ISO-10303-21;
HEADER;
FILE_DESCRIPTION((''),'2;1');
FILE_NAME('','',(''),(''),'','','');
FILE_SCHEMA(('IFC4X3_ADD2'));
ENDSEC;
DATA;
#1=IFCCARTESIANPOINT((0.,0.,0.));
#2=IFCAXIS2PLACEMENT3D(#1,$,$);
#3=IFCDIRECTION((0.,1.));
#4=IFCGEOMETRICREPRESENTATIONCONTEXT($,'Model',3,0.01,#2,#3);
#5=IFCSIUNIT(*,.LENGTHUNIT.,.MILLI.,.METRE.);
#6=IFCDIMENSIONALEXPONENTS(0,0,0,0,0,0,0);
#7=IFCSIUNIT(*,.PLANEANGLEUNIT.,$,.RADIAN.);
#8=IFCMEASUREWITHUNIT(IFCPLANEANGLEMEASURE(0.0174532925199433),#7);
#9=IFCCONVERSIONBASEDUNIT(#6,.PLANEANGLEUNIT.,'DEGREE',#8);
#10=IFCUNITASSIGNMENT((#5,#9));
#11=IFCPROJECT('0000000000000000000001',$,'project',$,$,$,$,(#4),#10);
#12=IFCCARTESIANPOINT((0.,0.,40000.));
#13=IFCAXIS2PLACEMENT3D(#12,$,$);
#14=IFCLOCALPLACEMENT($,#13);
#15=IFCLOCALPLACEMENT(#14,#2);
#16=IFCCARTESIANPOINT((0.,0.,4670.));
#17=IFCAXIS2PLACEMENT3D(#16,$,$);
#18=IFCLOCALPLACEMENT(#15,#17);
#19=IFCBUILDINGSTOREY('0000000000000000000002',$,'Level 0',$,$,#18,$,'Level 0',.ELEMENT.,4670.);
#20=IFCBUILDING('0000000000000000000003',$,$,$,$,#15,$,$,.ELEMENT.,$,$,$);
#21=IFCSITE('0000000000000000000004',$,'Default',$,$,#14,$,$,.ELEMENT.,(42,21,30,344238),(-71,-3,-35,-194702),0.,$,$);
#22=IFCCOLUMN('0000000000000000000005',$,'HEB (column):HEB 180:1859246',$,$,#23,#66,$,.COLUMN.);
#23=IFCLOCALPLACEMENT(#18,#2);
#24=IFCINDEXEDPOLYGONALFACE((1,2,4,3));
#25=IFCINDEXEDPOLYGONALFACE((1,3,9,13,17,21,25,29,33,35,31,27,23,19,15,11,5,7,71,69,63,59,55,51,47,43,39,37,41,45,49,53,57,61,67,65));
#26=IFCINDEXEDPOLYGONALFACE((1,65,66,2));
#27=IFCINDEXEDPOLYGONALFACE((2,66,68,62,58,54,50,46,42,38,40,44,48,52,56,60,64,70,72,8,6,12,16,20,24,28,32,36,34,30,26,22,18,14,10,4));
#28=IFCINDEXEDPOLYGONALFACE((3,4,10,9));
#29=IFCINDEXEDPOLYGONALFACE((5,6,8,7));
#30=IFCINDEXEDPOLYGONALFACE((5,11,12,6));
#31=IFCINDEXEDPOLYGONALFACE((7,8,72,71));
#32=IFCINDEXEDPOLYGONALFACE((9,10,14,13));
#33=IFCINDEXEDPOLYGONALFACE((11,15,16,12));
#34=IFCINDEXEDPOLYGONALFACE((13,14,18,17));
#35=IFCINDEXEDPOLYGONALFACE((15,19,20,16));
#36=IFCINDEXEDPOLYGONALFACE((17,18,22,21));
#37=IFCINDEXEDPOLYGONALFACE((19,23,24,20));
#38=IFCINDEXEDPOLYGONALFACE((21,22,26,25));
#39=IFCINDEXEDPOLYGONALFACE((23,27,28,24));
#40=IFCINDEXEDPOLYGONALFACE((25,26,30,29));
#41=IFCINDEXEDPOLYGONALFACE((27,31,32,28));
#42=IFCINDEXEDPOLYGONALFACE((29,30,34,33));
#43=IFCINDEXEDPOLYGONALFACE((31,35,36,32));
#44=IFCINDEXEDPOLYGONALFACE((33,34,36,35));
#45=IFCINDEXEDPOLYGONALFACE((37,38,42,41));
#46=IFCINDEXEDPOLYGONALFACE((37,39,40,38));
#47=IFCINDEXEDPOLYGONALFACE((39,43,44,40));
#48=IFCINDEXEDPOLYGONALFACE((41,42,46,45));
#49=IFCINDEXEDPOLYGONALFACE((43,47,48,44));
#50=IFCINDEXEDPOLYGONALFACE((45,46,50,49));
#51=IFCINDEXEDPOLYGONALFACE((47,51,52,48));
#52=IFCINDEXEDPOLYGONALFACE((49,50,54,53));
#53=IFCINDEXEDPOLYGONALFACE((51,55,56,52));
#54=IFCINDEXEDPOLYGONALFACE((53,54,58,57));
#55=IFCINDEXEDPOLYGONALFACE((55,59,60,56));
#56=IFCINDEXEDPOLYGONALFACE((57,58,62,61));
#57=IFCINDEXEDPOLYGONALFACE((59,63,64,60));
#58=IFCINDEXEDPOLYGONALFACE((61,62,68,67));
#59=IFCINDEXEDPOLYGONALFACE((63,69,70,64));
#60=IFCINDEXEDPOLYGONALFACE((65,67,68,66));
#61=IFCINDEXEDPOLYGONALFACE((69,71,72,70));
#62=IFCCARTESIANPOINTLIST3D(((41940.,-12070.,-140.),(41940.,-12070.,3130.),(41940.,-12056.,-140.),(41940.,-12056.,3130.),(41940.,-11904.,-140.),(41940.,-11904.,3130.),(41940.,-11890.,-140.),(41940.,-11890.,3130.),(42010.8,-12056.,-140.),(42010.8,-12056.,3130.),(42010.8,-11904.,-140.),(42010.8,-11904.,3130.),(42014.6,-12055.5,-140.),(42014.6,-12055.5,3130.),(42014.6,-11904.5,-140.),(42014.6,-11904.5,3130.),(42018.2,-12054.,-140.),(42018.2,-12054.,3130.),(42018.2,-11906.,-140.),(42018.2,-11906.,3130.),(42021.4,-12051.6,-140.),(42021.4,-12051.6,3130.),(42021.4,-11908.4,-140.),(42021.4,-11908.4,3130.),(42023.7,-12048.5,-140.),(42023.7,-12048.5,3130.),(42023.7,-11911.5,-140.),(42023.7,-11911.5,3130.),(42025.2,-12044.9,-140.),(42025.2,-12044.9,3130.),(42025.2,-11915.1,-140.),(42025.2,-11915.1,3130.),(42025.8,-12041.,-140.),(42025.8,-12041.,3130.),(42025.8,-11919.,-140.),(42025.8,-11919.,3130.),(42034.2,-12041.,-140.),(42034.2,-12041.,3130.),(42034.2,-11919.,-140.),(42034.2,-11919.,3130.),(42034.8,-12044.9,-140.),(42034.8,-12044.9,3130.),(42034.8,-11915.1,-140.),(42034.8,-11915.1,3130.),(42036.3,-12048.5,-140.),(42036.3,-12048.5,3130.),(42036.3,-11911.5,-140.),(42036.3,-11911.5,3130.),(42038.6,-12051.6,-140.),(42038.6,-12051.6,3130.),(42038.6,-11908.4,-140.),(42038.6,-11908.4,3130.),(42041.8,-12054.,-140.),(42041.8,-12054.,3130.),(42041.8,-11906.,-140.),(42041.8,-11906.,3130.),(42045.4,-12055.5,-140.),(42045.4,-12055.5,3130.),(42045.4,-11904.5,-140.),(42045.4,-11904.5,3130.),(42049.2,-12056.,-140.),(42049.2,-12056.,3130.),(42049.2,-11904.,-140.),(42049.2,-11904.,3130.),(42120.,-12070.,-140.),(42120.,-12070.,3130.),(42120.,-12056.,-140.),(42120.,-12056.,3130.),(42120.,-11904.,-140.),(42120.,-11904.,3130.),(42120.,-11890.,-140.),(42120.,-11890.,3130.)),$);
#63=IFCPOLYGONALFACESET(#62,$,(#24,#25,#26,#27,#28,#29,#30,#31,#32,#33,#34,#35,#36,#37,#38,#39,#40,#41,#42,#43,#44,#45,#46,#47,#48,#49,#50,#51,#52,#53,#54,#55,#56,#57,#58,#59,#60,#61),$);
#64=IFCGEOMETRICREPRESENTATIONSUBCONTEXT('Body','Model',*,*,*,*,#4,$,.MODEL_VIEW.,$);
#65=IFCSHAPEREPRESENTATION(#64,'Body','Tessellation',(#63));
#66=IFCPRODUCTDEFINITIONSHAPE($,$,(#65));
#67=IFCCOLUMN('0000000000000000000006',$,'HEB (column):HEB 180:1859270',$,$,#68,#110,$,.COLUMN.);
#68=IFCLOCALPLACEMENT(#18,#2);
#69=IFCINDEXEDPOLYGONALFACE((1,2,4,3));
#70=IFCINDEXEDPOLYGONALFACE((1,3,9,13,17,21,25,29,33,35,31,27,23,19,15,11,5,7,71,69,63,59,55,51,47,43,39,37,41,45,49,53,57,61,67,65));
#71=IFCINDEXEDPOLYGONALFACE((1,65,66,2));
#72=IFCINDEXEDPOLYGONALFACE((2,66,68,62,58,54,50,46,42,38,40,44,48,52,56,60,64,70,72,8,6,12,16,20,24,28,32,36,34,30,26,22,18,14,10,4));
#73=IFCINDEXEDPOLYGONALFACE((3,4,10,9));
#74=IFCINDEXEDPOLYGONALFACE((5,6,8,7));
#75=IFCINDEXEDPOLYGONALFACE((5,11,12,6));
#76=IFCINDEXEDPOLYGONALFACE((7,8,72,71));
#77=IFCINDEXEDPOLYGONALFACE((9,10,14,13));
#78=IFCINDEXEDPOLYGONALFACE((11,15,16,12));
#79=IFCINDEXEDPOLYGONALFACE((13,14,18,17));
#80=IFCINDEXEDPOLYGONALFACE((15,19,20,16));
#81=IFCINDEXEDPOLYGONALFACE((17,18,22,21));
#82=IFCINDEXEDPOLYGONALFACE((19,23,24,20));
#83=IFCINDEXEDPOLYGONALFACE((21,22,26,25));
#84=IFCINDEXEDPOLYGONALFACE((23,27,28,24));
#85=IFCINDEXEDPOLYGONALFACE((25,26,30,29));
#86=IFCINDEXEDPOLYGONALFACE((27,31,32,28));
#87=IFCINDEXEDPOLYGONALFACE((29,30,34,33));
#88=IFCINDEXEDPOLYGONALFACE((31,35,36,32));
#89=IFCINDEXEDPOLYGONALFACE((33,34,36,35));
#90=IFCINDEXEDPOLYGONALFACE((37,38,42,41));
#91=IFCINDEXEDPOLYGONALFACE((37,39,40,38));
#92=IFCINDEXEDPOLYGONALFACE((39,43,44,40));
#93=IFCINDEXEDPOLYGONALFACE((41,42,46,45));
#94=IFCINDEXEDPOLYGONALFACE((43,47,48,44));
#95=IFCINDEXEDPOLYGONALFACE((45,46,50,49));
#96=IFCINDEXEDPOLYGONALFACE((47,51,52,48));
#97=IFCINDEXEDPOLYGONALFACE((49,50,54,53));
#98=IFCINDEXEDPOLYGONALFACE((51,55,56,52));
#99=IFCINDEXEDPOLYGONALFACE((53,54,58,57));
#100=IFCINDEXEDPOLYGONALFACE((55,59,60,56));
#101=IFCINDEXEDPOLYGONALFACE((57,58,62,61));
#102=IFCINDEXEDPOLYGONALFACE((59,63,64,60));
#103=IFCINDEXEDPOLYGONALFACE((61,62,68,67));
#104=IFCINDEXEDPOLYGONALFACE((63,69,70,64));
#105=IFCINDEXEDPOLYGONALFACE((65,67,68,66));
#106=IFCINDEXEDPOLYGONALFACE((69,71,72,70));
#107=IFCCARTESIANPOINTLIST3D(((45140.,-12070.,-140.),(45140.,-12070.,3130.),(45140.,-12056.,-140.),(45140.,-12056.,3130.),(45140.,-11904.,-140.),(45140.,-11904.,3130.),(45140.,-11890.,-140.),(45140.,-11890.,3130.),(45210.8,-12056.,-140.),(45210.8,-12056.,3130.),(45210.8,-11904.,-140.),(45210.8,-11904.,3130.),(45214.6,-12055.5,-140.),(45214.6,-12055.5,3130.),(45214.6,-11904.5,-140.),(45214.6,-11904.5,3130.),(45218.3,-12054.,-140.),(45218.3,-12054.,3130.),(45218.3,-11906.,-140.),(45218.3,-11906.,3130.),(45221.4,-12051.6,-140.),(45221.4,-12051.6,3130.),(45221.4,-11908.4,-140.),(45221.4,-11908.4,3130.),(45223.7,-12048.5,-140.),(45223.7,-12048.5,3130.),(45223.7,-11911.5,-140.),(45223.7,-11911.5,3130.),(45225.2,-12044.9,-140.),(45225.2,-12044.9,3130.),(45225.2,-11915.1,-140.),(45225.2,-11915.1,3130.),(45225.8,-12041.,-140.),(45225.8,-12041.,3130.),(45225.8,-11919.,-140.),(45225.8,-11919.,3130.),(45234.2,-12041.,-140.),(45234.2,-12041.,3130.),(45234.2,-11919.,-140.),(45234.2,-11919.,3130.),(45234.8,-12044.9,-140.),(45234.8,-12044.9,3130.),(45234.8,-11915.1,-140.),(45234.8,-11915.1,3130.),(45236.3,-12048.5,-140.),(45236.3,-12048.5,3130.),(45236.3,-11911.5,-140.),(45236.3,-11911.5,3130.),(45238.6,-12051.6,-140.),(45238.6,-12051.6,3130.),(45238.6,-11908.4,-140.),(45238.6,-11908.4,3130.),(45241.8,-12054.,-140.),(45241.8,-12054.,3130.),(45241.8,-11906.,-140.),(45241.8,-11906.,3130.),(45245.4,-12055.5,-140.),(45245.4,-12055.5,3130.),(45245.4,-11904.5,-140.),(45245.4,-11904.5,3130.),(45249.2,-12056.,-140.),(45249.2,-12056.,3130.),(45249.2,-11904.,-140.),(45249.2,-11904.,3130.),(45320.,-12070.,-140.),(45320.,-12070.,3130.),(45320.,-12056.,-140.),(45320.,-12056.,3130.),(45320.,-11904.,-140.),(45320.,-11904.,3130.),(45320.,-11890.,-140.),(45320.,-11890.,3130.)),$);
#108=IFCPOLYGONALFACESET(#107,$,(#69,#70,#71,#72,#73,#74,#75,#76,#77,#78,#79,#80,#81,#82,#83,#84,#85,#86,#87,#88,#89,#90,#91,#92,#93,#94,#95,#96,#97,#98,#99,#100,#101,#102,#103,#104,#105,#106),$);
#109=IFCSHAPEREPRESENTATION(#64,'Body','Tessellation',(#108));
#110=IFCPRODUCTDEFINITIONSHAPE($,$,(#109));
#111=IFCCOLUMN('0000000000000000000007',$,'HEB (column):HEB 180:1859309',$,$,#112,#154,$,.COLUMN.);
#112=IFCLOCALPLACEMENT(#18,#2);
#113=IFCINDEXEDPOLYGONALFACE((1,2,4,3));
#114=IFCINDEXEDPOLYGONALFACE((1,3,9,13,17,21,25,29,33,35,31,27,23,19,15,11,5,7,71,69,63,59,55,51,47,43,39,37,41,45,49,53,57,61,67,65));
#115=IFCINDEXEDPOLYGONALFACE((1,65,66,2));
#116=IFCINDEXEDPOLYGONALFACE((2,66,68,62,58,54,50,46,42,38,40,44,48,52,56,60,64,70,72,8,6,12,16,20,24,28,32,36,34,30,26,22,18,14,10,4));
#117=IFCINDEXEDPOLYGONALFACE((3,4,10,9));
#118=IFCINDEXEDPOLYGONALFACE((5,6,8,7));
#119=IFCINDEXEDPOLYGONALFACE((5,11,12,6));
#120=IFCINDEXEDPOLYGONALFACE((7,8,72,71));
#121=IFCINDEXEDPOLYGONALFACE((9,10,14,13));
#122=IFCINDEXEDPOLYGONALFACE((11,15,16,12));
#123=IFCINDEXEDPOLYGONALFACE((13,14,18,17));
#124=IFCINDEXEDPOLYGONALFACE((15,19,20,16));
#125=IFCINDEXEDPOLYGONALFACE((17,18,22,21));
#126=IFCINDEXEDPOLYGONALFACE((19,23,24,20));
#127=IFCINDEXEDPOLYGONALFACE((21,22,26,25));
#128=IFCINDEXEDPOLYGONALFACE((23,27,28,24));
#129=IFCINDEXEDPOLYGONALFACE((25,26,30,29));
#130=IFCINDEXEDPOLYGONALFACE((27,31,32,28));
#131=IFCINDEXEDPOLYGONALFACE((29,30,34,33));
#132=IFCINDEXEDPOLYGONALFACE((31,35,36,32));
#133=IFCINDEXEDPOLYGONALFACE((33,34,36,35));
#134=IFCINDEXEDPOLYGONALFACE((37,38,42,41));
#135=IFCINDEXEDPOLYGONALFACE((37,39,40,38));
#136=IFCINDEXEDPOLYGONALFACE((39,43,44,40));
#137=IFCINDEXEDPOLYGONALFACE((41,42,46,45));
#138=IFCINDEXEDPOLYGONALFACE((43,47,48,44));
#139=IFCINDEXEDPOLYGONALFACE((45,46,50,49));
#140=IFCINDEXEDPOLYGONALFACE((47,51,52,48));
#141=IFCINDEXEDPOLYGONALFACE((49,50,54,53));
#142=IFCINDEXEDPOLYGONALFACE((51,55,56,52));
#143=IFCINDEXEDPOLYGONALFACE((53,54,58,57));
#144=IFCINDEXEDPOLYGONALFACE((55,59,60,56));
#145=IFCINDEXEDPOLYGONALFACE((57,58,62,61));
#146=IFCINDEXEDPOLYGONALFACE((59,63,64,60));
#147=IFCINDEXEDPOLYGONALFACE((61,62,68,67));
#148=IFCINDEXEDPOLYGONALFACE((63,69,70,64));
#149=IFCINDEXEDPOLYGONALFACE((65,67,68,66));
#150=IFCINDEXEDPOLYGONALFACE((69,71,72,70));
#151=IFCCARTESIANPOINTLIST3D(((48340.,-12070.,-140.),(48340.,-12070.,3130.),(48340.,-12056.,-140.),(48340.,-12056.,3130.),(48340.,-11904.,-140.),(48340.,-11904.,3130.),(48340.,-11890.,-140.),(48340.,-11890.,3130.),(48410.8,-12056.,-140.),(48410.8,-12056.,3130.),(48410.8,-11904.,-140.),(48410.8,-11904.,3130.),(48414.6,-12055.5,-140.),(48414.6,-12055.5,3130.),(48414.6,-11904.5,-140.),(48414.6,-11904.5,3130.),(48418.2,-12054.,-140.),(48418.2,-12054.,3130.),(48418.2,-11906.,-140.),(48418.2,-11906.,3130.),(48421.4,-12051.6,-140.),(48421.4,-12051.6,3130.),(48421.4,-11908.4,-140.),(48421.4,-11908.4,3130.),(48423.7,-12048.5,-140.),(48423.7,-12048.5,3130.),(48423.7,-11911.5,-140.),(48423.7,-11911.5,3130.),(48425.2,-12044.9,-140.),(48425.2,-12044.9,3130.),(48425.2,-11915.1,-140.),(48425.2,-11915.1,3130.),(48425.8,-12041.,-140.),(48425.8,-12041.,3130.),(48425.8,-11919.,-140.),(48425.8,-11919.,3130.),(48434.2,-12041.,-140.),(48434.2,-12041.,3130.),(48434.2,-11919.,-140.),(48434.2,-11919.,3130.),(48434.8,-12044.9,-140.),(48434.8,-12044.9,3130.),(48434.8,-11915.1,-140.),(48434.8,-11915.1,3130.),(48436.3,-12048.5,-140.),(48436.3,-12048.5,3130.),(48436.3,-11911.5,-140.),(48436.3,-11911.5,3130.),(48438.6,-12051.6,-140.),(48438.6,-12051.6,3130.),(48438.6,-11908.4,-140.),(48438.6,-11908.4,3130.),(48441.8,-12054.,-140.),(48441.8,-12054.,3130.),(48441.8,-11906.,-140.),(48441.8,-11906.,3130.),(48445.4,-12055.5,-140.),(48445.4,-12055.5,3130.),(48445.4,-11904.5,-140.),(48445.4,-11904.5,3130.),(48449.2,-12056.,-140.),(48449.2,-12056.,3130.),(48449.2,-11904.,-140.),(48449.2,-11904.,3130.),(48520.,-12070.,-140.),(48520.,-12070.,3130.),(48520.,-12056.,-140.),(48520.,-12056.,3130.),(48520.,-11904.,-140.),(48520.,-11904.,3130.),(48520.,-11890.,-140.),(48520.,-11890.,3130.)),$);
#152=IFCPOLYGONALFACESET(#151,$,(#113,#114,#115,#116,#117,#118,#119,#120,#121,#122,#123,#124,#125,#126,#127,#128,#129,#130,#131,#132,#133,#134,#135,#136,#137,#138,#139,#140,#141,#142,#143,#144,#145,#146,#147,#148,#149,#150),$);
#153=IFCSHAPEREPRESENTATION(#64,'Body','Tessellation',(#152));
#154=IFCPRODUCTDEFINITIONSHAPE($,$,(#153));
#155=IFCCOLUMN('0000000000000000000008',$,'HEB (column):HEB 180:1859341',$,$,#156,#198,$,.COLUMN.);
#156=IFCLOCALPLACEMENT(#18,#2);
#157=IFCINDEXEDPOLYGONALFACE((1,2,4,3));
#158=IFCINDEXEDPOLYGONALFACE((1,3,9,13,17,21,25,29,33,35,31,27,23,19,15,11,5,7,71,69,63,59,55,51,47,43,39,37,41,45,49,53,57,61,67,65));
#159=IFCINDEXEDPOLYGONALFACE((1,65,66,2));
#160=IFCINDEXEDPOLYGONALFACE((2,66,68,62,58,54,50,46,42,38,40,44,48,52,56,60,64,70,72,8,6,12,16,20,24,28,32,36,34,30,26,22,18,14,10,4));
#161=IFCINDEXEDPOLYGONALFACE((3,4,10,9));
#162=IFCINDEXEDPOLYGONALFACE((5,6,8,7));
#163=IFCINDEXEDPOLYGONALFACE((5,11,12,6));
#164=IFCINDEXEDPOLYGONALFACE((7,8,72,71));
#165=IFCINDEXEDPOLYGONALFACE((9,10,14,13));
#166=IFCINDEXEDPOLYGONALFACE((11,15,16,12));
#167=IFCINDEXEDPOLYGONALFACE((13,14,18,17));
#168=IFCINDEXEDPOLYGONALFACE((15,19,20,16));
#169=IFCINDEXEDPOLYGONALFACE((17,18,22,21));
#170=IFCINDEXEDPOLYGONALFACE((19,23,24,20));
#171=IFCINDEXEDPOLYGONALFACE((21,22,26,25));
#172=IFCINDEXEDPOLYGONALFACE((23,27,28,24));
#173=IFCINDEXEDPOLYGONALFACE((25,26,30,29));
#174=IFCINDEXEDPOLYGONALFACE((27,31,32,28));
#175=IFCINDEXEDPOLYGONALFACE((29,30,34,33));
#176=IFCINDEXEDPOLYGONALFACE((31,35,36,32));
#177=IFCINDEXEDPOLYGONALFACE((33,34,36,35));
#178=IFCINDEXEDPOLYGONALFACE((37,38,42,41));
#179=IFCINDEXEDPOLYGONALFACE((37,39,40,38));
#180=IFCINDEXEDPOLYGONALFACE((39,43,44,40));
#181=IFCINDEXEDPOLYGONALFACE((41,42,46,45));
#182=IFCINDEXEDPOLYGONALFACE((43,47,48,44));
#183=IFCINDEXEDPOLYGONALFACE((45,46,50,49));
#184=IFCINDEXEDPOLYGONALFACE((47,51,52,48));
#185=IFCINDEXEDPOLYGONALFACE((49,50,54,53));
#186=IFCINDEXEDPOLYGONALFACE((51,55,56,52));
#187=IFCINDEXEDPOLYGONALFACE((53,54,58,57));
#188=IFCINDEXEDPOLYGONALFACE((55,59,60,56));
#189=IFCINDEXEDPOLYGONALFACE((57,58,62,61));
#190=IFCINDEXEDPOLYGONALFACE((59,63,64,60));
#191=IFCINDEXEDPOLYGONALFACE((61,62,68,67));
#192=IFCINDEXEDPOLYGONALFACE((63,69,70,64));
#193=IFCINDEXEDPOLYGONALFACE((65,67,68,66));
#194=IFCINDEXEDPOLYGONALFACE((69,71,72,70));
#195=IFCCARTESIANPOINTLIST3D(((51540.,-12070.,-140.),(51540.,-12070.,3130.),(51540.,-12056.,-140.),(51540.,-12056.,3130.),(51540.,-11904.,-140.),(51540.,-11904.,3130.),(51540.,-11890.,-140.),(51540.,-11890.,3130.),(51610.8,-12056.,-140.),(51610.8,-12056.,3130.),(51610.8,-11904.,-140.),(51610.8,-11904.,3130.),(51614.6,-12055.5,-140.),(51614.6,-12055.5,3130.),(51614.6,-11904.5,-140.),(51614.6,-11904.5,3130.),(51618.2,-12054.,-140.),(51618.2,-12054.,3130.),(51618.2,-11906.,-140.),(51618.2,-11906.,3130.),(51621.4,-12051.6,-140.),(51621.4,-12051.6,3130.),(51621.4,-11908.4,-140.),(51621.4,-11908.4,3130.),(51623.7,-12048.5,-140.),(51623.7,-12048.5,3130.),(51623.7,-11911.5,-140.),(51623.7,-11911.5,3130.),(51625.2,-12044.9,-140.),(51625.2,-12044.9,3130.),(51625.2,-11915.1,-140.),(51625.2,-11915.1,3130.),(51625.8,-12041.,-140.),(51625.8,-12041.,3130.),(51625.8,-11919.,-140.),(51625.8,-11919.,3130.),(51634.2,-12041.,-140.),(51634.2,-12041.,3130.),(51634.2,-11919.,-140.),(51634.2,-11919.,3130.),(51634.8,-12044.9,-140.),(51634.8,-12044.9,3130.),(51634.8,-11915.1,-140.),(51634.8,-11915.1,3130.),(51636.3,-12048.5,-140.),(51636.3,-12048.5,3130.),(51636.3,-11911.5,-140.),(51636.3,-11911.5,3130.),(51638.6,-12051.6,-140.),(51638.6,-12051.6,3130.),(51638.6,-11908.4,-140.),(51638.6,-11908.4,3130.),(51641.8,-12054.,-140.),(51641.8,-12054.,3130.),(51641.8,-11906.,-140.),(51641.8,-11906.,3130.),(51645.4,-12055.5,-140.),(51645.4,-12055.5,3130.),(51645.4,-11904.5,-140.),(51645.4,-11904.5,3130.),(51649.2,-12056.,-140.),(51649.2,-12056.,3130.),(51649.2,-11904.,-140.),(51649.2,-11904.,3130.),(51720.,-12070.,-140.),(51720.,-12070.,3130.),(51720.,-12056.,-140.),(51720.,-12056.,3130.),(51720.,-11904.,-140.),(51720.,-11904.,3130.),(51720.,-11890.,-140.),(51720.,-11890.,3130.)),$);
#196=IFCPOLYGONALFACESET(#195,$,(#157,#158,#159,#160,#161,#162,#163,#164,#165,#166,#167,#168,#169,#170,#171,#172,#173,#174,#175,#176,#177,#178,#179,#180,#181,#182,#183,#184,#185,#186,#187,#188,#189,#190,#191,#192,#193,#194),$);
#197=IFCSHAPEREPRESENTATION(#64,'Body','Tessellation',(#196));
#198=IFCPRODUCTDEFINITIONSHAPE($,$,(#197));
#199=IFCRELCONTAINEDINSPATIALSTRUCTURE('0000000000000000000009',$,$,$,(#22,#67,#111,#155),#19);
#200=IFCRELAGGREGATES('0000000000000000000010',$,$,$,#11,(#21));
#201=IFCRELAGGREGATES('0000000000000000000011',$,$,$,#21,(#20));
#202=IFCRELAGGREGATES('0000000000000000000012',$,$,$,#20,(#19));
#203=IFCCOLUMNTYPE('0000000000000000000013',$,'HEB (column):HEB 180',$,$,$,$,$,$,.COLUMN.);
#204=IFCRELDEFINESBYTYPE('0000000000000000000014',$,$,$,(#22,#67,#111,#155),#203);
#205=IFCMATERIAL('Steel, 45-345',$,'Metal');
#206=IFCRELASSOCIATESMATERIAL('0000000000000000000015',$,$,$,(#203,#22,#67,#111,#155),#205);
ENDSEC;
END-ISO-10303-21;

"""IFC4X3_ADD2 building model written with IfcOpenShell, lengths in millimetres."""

from ifc_helpers import new_model, entity, si_unit, converted_unit, direction, frame, origin, origin_2d_with_axis, place, context, subcontext, project, spatial, i_section, extrude, source, transform, mapped, material, material_profile, profile_set, profile_usage, type_object, type_shapes, element, save


model = new_model("IFC4X3_ADD2")

# Units and contexts
model_context = context("Model", 3, precision=0.01, world=origin(), true_north=direction((0.0, 1.0)))
body_context = subcontext(model_context, "Body", "Model", "MODEL_VIEW")
ifc_project = project(units=[si_unit("LENGTHUNIT", "METRE", prefix="MILLI"), converted_unit("PLANEANGLEUNIT", "DEGREE", entity("IfcPlaneAngleMeasure", 0.0174532925199433), si_unit("PLANEANGLEUNIT", "RADIAN"), dimensions=[0, 0, 0, 0, 0, 0, 0])], contexts=[model_context])

# Site, building, storey
site_placement = place(None, frame((0.0, 0.0, 40000.0)))
site = spatial("IfcSite", under=ifc_project, at=site_placement, Name="Default", CompositionType="ELEMENT", RefLatitude=(42, 21, 30, 344238), RefLongitude=(-71, -3, -35, -194702), RefElevation=0.0)
building_placement = place(site_placement, origin())
building = spatial("IfcBuilding", under=site, at=building_placement, CompositionType="ELEMENT")
storey_placement = place(building_placement, frame((0.0, 0.0, 4670.0)))
storey = spatial("IfcBuildingStorey", under=building, at=storey_placement, Name="Level 0", LongName="Level 0", CompositionType="ELEMENT", Elevation=4670.0)

# Columns
ifc_material_1 = material(Name="Steel, 45-345", Category="Metal")
ifc_material_profile_1 = material_profile(ifc_material_1, i_section(OverallWidth=180.0, OverallDepth=180.0, WebThickness=8.5, FlangeThickness=14.0, FilletRadius=15.0, at=origin_2d_with_axis()), Name="HEB 180")
ifc_profile_set_1 = profile_set([ifc_material_profile_1], Name="HEB 180")
ifc_profile_usage_1 = profile_usage(ifc_profile_set_1)
column_type = type_object("IfcColumnType", Name="HEB (column):HEB 180", PredefinedType="COLUMN", material=ifc_profile_set_1)
shared_shape_1 = source(origin(), body_context, "Body", "SweptSolid", [
    extrude(i_section(OverallWidth=180.0, OverallDepth=180.0, WebThickness=8.5, FlangeThickness=14.0, FilletRadius=15.0, at=origin_2d_with_axis()), frame((0.0, 0.0, 4530.0), z_axis=(0.0, 0.0, 1.0), x_axis=(-1.0, 0.0, 0.0)), (0.0, 0.0, 1.0), 3270.0),
])
type_shapes(column_type, [shared_shape_1])
for number, where, name in (
    (1, (42030.0, -11980.0, -4670.0), "HEB (column):HEB 180:1859246"),
    (2, (45230.0, -11980.0, -4670.0), "HEB (column):HEB 180:1859270"),
    (3, (48430.0, -11980.0, -4670.0), "HEB (column):HEB 180:1859309"),
    (4, (51630.0, -11980.0, -4670.0), "HEB (column):HEB 180:1859341"),
):
    element("IfcColumn", number, at=place(storey_placement, frame(where)), inside=storey, type_object=column_type, material=ifc_profile_usage_1, Name=name, PredefinedType="COLUMN", context=body_context, shape_type="MappedRepresentation", body=[
        mapped(shared_shape_1, transform((0.0, 0.0, 0.0), scale=1.0)),
    ])

save(model, "model.ifc")
